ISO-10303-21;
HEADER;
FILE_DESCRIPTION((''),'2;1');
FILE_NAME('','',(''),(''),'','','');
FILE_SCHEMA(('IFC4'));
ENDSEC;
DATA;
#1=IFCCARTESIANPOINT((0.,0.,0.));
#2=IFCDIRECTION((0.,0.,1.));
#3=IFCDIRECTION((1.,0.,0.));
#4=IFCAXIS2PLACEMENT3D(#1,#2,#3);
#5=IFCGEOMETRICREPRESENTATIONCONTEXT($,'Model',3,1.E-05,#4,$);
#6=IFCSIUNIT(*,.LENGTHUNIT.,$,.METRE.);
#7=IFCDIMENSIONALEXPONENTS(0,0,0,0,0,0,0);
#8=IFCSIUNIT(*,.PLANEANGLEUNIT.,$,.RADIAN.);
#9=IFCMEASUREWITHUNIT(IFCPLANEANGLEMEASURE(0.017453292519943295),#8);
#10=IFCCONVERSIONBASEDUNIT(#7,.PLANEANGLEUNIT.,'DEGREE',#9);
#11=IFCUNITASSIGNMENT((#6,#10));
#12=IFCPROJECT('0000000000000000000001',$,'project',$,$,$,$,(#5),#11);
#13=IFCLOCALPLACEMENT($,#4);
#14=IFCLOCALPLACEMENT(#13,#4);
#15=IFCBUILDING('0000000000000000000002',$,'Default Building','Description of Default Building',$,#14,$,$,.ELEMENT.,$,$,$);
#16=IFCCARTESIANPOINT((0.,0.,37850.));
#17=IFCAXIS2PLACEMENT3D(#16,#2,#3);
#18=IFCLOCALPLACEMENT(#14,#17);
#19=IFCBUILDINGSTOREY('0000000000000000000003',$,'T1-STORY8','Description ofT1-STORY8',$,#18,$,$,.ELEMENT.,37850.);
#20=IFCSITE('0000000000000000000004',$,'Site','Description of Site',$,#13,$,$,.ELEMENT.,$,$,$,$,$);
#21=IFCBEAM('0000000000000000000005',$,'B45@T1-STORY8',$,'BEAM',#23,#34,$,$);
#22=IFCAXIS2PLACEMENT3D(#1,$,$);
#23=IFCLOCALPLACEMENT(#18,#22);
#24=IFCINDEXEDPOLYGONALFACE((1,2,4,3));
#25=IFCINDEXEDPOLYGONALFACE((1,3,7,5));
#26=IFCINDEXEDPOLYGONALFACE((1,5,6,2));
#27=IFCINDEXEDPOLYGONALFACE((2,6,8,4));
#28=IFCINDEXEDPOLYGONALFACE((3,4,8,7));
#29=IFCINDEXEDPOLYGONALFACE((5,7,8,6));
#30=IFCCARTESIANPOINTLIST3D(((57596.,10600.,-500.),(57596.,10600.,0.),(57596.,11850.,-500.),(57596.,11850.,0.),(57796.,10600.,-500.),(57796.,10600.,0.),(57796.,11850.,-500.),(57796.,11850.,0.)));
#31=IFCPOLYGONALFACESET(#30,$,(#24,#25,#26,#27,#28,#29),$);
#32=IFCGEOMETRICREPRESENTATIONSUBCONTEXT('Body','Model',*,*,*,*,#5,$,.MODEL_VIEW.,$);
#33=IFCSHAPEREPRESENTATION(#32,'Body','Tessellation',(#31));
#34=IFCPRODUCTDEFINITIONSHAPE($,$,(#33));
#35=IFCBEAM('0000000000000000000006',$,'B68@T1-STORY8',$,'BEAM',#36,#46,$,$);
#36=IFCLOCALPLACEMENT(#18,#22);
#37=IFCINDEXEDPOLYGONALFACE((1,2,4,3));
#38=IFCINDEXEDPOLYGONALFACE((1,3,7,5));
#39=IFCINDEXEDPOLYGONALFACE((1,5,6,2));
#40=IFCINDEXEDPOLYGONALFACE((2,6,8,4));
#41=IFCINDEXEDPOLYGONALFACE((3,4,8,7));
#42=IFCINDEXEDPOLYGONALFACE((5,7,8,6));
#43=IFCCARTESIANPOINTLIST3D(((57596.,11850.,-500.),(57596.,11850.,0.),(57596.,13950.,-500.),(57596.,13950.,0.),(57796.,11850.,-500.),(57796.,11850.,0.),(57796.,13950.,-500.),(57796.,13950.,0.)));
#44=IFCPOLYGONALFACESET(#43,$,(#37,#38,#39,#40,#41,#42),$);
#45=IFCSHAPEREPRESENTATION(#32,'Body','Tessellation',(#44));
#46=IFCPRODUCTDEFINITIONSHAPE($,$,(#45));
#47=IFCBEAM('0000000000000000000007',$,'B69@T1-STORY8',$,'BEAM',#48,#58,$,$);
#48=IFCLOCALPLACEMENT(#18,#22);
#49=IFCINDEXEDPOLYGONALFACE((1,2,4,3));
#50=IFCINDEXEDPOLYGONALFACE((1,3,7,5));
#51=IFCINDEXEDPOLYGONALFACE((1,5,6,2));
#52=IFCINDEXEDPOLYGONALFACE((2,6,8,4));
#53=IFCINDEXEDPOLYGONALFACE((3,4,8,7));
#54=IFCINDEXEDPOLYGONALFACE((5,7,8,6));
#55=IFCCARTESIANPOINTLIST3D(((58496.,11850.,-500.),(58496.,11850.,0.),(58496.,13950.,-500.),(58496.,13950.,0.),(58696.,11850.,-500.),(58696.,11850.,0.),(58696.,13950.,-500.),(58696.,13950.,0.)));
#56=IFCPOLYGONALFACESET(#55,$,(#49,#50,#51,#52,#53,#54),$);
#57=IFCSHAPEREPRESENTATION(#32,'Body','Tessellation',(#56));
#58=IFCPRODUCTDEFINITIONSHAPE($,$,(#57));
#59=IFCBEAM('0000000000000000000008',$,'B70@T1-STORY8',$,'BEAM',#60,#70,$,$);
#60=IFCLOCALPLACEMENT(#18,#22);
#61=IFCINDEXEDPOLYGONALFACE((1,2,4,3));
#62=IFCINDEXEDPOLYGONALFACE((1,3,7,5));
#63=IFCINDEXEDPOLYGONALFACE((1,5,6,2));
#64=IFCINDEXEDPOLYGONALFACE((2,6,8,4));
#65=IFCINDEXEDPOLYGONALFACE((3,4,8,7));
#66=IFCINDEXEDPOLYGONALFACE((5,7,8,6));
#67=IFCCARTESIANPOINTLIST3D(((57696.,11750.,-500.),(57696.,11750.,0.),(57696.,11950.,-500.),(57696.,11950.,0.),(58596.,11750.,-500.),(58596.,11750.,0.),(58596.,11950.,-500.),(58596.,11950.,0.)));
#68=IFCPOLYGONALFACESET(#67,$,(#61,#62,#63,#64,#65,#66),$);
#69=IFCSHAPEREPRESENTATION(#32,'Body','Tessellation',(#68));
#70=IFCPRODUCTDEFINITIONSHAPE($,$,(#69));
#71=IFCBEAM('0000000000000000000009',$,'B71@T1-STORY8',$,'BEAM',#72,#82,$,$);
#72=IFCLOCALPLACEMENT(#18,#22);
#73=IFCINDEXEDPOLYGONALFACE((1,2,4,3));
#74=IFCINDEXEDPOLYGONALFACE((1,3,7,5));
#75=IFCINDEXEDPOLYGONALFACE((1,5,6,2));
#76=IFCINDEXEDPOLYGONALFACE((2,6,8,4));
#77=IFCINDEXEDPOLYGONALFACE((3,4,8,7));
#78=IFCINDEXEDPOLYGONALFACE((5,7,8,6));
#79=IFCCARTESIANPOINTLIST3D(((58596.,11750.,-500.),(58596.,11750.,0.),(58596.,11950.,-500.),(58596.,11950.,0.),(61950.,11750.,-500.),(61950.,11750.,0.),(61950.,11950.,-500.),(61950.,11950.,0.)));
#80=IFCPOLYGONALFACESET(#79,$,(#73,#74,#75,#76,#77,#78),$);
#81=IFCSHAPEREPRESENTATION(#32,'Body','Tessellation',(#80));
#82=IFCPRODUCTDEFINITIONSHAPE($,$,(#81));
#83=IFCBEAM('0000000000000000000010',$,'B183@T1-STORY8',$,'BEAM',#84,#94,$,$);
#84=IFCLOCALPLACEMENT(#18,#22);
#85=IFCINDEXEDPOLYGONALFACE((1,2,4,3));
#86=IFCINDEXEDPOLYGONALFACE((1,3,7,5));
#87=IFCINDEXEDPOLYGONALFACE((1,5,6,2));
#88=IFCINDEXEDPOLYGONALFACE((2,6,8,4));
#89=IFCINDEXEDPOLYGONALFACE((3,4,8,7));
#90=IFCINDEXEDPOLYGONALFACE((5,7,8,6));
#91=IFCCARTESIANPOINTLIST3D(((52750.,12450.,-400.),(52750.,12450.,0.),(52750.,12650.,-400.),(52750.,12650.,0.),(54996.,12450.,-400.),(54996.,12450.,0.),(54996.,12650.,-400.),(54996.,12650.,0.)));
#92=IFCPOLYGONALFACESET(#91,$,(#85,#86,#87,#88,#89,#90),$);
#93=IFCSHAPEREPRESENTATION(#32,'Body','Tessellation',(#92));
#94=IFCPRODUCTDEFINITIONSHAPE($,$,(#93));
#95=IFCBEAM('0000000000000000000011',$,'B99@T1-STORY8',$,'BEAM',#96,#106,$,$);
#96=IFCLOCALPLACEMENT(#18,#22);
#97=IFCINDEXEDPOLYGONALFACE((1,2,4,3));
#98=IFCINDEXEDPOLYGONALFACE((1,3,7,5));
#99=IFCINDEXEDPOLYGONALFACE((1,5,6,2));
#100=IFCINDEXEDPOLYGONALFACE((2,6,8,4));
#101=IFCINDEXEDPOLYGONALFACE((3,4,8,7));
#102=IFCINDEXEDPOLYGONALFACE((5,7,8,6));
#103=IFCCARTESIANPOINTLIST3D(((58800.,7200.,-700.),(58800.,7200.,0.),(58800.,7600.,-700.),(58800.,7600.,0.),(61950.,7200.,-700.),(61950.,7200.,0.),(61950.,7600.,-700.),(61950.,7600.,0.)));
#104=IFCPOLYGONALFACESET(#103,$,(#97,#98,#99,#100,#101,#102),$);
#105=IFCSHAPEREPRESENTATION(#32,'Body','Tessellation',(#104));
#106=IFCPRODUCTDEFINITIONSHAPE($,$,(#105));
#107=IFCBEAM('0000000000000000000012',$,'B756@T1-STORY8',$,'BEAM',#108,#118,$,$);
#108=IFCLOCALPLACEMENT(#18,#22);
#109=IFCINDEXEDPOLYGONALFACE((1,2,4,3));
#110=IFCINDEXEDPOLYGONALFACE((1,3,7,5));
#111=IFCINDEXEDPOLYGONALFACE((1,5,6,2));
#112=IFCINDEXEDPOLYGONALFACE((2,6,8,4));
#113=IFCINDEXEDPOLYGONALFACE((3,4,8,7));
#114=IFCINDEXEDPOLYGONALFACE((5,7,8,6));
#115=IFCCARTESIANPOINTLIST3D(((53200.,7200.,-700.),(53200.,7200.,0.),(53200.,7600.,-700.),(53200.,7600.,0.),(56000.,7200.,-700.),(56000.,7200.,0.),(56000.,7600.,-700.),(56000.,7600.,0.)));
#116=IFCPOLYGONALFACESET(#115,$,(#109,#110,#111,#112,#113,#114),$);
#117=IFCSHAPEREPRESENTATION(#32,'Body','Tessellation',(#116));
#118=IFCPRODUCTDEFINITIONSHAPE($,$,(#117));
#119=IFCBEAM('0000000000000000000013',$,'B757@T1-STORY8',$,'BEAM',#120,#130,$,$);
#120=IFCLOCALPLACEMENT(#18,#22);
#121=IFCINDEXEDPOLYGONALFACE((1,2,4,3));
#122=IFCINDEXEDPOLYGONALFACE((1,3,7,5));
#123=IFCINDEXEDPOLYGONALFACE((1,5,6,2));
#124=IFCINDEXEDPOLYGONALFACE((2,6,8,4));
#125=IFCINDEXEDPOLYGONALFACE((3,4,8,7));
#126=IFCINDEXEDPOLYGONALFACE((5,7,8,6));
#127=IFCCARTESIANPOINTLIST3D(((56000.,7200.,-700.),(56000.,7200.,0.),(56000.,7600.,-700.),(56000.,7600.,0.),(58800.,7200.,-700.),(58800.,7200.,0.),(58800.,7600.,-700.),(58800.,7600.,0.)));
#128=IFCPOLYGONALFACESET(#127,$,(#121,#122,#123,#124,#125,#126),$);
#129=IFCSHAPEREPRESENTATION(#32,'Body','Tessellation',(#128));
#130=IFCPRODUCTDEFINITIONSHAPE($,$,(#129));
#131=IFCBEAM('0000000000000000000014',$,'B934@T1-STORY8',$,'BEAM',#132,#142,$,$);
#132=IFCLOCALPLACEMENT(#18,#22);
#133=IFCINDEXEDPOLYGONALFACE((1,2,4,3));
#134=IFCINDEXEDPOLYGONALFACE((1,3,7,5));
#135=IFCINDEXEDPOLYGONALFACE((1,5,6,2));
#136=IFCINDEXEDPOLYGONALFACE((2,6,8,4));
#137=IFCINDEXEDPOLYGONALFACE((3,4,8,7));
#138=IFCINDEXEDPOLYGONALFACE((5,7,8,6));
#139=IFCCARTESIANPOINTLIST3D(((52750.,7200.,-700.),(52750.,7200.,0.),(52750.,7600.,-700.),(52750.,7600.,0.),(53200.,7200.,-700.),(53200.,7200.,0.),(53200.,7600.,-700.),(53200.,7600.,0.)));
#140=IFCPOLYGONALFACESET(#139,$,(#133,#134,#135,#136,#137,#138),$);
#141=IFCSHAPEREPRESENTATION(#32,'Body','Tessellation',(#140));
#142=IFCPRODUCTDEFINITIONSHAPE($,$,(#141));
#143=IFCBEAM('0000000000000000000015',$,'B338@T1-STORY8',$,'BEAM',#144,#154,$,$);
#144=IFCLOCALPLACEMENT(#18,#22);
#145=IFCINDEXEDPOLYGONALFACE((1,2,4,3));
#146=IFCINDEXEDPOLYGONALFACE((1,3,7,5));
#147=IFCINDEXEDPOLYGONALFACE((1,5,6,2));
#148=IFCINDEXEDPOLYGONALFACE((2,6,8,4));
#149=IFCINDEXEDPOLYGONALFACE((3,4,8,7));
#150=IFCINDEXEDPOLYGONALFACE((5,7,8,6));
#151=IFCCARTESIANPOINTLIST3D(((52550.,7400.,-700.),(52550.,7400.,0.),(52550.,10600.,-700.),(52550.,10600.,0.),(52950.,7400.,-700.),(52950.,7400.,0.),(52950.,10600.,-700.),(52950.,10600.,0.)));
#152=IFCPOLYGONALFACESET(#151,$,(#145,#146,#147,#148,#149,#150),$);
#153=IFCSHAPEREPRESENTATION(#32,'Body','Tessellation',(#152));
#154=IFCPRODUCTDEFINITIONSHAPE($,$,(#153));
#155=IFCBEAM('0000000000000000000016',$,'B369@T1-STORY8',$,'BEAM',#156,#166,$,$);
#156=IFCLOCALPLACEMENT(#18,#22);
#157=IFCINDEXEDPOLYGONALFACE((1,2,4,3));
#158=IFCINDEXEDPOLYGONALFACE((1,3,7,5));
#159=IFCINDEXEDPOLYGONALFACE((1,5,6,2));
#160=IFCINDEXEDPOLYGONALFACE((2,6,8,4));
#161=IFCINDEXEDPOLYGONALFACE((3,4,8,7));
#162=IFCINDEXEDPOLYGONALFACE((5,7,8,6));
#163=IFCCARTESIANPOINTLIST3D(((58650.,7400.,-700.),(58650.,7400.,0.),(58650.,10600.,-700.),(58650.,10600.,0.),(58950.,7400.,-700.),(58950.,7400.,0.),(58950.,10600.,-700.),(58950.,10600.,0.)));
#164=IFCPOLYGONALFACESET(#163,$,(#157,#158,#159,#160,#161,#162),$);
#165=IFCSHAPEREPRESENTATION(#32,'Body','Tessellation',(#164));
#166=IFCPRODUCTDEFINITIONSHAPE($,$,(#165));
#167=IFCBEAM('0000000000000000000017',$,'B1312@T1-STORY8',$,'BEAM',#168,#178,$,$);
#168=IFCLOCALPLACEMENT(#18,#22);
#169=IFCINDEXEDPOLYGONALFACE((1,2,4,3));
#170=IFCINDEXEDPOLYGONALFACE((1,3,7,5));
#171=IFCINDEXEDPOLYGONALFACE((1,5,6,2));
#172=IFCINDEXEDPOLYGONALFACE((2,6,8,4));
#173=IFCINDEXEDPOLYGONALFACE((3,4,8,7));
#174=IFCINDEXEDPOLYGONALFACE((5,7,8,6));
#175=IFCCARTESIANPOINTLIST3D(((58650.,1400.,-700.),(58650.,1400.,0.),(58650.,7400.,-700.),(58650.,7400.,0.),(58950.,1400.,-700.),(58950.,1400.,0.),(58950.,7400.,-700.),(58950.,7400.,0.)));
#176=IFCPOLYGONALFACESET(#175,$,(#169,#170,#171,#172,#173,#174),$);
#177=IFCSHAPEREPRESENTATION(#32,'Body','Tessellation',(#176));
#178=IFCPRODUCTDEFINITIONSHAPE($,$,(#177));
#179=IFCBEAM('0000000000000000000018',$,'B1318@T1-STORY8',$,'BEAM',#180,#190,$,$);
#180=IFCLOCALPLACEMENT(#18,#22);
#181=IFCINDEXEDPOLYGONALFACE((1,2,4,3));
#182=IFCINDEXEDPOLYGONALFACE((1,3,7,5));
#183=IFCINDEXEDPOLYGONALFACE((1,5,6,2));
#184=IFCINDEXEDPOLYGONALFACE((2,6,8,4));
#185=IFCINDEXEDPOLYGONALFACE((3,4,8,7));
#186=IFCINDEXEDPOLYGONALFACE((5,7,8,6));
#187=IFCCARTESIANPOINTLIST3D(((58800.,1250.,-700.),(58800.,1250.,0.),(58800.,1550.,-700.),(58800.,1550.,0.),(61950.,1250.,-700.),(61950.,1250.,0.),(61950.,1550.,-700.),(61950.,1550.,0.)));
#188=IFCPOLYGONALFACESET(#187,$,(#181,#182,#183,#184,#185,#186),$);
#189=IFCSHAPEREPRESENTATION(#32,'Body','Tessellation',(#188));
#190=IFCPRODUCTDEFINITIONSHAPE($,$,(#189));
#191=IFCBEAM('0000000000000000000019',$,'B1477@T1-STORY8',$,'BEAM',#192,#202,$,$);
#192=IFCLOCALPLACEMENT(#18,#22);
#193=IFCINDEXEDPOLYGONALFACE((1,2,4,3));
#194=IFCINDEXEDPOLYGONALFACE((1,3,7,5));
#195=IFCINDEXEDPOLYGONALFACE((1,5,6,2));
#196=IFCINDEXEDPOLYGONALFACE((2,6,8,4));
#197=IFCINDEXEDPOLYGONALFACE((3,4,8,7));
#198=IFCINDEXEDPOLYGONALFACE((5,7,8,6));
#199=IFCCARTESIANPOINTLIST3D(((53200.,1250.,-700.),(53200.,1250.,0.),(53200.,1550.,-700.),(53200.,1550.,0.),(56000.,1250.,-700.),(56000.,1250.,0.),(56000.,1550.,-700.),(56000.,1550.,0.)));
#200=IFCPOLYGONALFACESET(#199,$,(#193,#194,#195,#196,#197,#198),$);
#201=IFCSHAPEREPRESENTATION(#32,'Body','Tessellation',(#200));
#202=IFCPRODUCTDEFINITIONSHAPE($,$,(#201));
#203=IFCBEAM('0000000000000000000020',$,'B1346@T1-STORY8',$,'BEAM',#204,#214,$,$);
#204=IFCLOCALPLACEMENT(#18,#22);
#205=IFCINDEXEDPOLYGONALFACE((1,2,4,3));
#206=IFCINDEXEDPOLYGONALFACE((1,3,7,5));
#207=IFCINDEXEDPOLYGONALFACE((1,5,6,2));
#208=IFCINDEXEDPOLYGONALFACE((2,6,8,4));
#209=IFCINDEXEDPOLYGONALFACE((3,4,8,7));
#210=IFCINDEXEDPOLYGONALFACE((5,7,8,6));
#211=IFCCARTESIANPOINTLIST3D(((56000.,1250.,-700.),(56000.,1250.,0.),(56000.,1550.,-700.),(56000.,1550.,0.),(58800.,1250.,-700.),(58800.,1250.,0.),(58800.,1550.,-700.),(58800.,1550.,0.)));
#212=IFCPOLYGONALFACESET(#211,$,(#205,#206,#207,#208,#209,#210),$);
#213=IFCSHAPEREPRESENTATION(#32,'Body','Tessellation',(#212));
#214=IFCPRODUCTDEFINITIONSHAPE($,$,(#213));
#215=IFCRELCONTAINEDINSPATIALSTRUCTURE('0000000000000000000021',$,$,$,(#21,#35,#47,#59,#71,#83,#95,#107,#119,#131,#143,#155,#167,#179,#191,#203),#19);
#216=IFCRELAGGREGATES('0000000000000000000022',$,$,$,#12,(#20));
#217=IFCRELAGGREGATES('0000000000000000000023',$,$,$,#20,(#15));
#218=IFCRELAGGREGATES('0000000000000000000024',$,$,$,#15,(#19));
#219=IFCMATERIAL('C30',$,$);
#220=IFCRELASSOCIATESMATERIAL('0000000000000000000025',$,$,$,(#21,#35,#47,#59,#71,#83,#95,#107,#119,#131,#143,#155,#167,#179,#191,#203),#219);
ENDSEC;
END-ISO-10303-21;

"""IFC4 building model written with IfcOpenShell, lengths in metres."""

from ifc_helpers import new_model, entity, si_unit, converted_unit, frame, origin_with_axes, place, context, subcontext, project, spatial, rectangle, extrude, material, element, save


model = new_model("IFC4")

# Units and contexts
model_context = context("Model", 3, precision=1e-05, world=origin_with_axes())
body_context = subcontext(model_context, "Body", "Model", "MODEL_VIEW")
ifc_project = project(units=[si_unit("LENGTHUNIT", "METRE"), converted_unit("PLANEANGLEUNIT", "DEGREE", entity("IfcPlaneAngleMeasure", 0.017453292519943295), si_unit("PLANEANGLEUNIT", "RADIAN"), dimensions=[0, 0, 0, 0, 0, 0, 0])], contexts=[model_context])

# Site, building, storey
site_placement = place(None, origin_with_axes())
site = spatial("IfcSite", under=ifc_project, at=site_placement, Name="Site", Description="Description of Site", CompositionType="ELEMENT")
building_placement = place(site_placement, origin_with_axes())
building = spatial("IfcBuilding", under=site, at=building_placement, Name="Default Building", Description="Description of Default Building", CompositionType="ELEMENT")
storey_placement = place(building_placement, frame((0.0, 0.0, 37850.0), z_axis=(0.0, 0.0, 1.0), x_axis=(1.0, 0.0, 0.0)))
storey = spatial("IfcBuildingStorey", under=building, at=storey_placement, Name="T1-STORY8", Description="Description ofT1-STORY8", CompositionType="ELEMENT", Elevation=37850.0)

# Beams
ifc_material_1 = material(Name="C30")
beam_1_placement = place(storey_placement, frame((57696.0, 10600.0, -250.0), z_axis=(0.0, 1.0, 0.0), x_axis=(-1.0, 0.0, 0.0)))
element("IfcBeam", 1, at=beam_1_placement, inside=storey, material=ifc_material_1, Name="B45@T1-STORY8", ObjectType="BEAM", context=body_context, shape_type="SweptSolid", body=[
    extrude(rectangle(XDim=200.0, YDim=500.0), origin_with_axes(), (0.0, 0.0, 1.0), 1250.0),
])
for number, where, z_axis, x_axis, name in (
    (2, (57696.0, 11850.0, -250.0), (0.0, 1.0, 0.0), (-1.0, 0.0, 0.0), "B68@T1-STORY8"),
    (3, (58596.0, 11850.0, -250.0), (0.0, 1.0, 0.0), (-1.0, 0.0, 0.0), "B69@T1-STORY8"),
):
    element("IfcBeam", number, at=place(storey_placement, frame(where, z_axis=z_axis, x_axis=x_axis)), inside=storey, material=ifc_material_1, Name=name, ObjectType="BEAM", context=body_context, shape_type="SweptSolid", body=[
        extrude(rectangle(XDim=200.0, YDim=500.0), origin_with_axes(), (0.0, 0.0, 1.0), 2100.0),
    ])
beam_2_placement = place(storey_placement, frame((57696.0, 11850.0, -250.0), z_axis=(1.0, 0.0, 0.0), x_axis=(0.0, 1.0, 0.0)))
element("IfcBeam", 4, at=beam_2_placement, inside=storey, material=ifc_material_1, Name="B70@T1-STORY8", ObjectType="BEAM", context=body_context, shape_type="SweptSolid", body=[
    extrude(rectangle(XDim=200.0, YDim=500.0), origin_with_axes(), (0.0, 0.0, 1.0), 900.0),
])
beam_3_placement = place(storey_placement, frame((58596.0, 11850.0, -250.0), z_axis=(1.0, 0.0, 0.0), x_axis=(0.0, 1.0, 0.0)))
element("IfcBeam", 5, at=beam_3_placement, inside=storey, material=ifc_material_1, Name="B71@T1-STORY8", ObjectType="BEAM", context=body_context, shape_type="SweptSolid", body=[
    extrude(rectangle(XDim=200.0, YDim=500.0), origin_with_axes(), (0.0, 0.0, 1.0), 3354.0),
])
beam_4_placement = place(storey_placement, frame((52750.0, 12550.0, -200.0), z_axis=(1.0, 0.0, 0.0), x_axis=(0.0, 1.0, 0.0)))
element("IfcBeam", 6, at=beam_4_placement, inside=storey, material=ifc_material_1, Name="B183@T1-STORY8", ObjectType="BEAM", context=body_context, shape_type="SweptSolid", body=[
    extrude(rectangle(XDim=200.0, YDim=400.0), origin_with_axes(), (0.0, 0.0, 1.0), 2246.0),
])
beam_5_placement = place(storey_placement, frame((58800.0, 7400.0, -350.0), z_axis=(1.0, 0.0, 0.0), x_axis=(0.0, 1.0, 0.0)))
element("IfcBeam", 7, at=beam_5_placement, inside=storey, material=ifc_material_1, Name="B99@T1-STORY8", ObjectType="BEAM", context=body_context, shape_type="SweptSolid", body=[
    extrude(rectangle(XDim=400.0, YDim=700.0), origin_with_axes(), (0.0, 0.0, 1.0), 3150.0),
])
for number, where, z_axis, x_axis, name in (
    (8, (53200.0, 7400.0, -350.0), (1.0, 0.0, 0.0), (0.0, 1.0, 0.0), "B756@T1-STORY8"),
    (9, (56000.0, 7400.0, -350.0), (1.0, 0.0, 0.0), (0.0, 1.0, 0.0), "B757@T1-STORY8"),
):
    element("IfcBeam", number, at=place(storey_placement, frame(where, z_axis=z_axis, x_axis=x_axis)), inside=storey, material=ifc_material_1, Name=name, ObjectType="BEAM", context=body_context, shape_type="SweptSolid", body=[
        extrude(rectangle(XDim=400.0, YDim=700.0), origin_with_axes(), (0.0, 0.0, 1.0), 2800.0),
    ])
beam_6_placement = place(storey_placement, frame((52750.0, 7400.0, -350.0), z_axis=(1.0, 0.0, 0.0), x_axis=(0.0, 1.0, 0.0)))
element("IfcBeam", 10, at=beam_6_placement, inside=storey, material=ifc_material_1, Name="B934@T1-STORY8", ObjectType="BEAM", context=body_context, shape_type="SweptSolid", body=[
    extrude(rectangle(XDim=400.0, YDim=700.0), origin_with_axes(), (0.0, 0.0, 1.0), 450.0),
])
beam_7_placement = place(storey_placement, frame((52750.0, 7400.0, -350.0), z_axis=(0.0, 1.0, 0.0), x_axis=(-1.0, 0.0, 0.0)))
element("IfcBeam", 11, at=beam_7_placement, inside=storey, material=ifc_material_1, Name="B338@T1-STORY8", ObjectType="BEAM", context=body_context, shape_type="SweptSolid", body=[
    extrude(rectangle(XDim=400.0, YDim=700.0), origin_with_axes(), (0.0, 0.0, 1.0), 3200.0),
])
beam_8_placement = place(storey_placement, frame((58800.0, 7400.0, -350.0), z_axis=(0.0, 1.0, 0.0), x_axis=(-1.0, 0.0, 0.0)))
element("IfcBeam", 12, at=beam_8_placement, inside=storey, material=ifc_material_1, Name="B369@T1-STORY8", ObjectType="BEAM", context=body_context, shape_type="SweptSolid", body=[
    extrude(rectangle(XDim=300.0, YDim=700.0), origin_with_axes(), (0.0, 0.0, 1.0), 3200.0),
])
beam_9_placement = place(storey_placement, frame((58800.0, 1400.0, -350.0), z_axis=(0.0, 1.0, 0.0), x_axis=(-1.0, 0.0, 0.0)))
element("IfcBeam", 13, at=beam_9_placement, inside=storey, material=ifc_material_1, Name="B1312@T1-STORY8", ObjectType="BEAM", context=body_context, shape_type="SweptSolid", body=[
    extrude(rectangle(XDim=300.0, YDim=700.0), origin_with_axes(), (0.0, 0.0, 1.0), 6000.0),
])
beam_10_placement = place(storey_placement, frame((58800.0, 1400.0, -350.0), z_axis=(1.0, 0.0, 0.0), x_axis=(0.0, 1.0, 0.0)))
element("IfcBeam", 14, at=beam_10_placement, inside=storey, material=ifc_material_1, Name="B1318@T1-STORY8", ObjectType="BEAM", context=body_context, shape_type="SweptSolid", body=[
    extrude(rectangle(XDim=300.0, YDim=700.0), origin_with_axes(), (0.0, 0.0, 1.0), 3150.0),
])
for number, where, z_axis, x_axis, name in (
    (15, (53200.0, 1400.0, -350.0), (1.0, 0.0, 0.0), (0.0, 1.0, 0.0), "B1477@T1-STORY8"),
    (16, (56000.0, 1400.0, -350.0), (1.0, 0.0, 0.0), (0.0, 1.0, 0.0), "B1346@T1-STORY8"),
):
    element("IfcBeam", number, at=place(storey_placement, frame(where, z_axis=z_axis, x_axis=x_axis)), inside=storey, material=ifc_material_1, Name=name, ObjectType="BEAM", context=body_context, shape_type="SweptSolid", body=[
        extrude(rectangle(XDim=300.0, YDim=700.0), origin_with_axes(), (0.0, 0.0, 1.0), 2800.0),
    ])

save(model, "model.ifc")
